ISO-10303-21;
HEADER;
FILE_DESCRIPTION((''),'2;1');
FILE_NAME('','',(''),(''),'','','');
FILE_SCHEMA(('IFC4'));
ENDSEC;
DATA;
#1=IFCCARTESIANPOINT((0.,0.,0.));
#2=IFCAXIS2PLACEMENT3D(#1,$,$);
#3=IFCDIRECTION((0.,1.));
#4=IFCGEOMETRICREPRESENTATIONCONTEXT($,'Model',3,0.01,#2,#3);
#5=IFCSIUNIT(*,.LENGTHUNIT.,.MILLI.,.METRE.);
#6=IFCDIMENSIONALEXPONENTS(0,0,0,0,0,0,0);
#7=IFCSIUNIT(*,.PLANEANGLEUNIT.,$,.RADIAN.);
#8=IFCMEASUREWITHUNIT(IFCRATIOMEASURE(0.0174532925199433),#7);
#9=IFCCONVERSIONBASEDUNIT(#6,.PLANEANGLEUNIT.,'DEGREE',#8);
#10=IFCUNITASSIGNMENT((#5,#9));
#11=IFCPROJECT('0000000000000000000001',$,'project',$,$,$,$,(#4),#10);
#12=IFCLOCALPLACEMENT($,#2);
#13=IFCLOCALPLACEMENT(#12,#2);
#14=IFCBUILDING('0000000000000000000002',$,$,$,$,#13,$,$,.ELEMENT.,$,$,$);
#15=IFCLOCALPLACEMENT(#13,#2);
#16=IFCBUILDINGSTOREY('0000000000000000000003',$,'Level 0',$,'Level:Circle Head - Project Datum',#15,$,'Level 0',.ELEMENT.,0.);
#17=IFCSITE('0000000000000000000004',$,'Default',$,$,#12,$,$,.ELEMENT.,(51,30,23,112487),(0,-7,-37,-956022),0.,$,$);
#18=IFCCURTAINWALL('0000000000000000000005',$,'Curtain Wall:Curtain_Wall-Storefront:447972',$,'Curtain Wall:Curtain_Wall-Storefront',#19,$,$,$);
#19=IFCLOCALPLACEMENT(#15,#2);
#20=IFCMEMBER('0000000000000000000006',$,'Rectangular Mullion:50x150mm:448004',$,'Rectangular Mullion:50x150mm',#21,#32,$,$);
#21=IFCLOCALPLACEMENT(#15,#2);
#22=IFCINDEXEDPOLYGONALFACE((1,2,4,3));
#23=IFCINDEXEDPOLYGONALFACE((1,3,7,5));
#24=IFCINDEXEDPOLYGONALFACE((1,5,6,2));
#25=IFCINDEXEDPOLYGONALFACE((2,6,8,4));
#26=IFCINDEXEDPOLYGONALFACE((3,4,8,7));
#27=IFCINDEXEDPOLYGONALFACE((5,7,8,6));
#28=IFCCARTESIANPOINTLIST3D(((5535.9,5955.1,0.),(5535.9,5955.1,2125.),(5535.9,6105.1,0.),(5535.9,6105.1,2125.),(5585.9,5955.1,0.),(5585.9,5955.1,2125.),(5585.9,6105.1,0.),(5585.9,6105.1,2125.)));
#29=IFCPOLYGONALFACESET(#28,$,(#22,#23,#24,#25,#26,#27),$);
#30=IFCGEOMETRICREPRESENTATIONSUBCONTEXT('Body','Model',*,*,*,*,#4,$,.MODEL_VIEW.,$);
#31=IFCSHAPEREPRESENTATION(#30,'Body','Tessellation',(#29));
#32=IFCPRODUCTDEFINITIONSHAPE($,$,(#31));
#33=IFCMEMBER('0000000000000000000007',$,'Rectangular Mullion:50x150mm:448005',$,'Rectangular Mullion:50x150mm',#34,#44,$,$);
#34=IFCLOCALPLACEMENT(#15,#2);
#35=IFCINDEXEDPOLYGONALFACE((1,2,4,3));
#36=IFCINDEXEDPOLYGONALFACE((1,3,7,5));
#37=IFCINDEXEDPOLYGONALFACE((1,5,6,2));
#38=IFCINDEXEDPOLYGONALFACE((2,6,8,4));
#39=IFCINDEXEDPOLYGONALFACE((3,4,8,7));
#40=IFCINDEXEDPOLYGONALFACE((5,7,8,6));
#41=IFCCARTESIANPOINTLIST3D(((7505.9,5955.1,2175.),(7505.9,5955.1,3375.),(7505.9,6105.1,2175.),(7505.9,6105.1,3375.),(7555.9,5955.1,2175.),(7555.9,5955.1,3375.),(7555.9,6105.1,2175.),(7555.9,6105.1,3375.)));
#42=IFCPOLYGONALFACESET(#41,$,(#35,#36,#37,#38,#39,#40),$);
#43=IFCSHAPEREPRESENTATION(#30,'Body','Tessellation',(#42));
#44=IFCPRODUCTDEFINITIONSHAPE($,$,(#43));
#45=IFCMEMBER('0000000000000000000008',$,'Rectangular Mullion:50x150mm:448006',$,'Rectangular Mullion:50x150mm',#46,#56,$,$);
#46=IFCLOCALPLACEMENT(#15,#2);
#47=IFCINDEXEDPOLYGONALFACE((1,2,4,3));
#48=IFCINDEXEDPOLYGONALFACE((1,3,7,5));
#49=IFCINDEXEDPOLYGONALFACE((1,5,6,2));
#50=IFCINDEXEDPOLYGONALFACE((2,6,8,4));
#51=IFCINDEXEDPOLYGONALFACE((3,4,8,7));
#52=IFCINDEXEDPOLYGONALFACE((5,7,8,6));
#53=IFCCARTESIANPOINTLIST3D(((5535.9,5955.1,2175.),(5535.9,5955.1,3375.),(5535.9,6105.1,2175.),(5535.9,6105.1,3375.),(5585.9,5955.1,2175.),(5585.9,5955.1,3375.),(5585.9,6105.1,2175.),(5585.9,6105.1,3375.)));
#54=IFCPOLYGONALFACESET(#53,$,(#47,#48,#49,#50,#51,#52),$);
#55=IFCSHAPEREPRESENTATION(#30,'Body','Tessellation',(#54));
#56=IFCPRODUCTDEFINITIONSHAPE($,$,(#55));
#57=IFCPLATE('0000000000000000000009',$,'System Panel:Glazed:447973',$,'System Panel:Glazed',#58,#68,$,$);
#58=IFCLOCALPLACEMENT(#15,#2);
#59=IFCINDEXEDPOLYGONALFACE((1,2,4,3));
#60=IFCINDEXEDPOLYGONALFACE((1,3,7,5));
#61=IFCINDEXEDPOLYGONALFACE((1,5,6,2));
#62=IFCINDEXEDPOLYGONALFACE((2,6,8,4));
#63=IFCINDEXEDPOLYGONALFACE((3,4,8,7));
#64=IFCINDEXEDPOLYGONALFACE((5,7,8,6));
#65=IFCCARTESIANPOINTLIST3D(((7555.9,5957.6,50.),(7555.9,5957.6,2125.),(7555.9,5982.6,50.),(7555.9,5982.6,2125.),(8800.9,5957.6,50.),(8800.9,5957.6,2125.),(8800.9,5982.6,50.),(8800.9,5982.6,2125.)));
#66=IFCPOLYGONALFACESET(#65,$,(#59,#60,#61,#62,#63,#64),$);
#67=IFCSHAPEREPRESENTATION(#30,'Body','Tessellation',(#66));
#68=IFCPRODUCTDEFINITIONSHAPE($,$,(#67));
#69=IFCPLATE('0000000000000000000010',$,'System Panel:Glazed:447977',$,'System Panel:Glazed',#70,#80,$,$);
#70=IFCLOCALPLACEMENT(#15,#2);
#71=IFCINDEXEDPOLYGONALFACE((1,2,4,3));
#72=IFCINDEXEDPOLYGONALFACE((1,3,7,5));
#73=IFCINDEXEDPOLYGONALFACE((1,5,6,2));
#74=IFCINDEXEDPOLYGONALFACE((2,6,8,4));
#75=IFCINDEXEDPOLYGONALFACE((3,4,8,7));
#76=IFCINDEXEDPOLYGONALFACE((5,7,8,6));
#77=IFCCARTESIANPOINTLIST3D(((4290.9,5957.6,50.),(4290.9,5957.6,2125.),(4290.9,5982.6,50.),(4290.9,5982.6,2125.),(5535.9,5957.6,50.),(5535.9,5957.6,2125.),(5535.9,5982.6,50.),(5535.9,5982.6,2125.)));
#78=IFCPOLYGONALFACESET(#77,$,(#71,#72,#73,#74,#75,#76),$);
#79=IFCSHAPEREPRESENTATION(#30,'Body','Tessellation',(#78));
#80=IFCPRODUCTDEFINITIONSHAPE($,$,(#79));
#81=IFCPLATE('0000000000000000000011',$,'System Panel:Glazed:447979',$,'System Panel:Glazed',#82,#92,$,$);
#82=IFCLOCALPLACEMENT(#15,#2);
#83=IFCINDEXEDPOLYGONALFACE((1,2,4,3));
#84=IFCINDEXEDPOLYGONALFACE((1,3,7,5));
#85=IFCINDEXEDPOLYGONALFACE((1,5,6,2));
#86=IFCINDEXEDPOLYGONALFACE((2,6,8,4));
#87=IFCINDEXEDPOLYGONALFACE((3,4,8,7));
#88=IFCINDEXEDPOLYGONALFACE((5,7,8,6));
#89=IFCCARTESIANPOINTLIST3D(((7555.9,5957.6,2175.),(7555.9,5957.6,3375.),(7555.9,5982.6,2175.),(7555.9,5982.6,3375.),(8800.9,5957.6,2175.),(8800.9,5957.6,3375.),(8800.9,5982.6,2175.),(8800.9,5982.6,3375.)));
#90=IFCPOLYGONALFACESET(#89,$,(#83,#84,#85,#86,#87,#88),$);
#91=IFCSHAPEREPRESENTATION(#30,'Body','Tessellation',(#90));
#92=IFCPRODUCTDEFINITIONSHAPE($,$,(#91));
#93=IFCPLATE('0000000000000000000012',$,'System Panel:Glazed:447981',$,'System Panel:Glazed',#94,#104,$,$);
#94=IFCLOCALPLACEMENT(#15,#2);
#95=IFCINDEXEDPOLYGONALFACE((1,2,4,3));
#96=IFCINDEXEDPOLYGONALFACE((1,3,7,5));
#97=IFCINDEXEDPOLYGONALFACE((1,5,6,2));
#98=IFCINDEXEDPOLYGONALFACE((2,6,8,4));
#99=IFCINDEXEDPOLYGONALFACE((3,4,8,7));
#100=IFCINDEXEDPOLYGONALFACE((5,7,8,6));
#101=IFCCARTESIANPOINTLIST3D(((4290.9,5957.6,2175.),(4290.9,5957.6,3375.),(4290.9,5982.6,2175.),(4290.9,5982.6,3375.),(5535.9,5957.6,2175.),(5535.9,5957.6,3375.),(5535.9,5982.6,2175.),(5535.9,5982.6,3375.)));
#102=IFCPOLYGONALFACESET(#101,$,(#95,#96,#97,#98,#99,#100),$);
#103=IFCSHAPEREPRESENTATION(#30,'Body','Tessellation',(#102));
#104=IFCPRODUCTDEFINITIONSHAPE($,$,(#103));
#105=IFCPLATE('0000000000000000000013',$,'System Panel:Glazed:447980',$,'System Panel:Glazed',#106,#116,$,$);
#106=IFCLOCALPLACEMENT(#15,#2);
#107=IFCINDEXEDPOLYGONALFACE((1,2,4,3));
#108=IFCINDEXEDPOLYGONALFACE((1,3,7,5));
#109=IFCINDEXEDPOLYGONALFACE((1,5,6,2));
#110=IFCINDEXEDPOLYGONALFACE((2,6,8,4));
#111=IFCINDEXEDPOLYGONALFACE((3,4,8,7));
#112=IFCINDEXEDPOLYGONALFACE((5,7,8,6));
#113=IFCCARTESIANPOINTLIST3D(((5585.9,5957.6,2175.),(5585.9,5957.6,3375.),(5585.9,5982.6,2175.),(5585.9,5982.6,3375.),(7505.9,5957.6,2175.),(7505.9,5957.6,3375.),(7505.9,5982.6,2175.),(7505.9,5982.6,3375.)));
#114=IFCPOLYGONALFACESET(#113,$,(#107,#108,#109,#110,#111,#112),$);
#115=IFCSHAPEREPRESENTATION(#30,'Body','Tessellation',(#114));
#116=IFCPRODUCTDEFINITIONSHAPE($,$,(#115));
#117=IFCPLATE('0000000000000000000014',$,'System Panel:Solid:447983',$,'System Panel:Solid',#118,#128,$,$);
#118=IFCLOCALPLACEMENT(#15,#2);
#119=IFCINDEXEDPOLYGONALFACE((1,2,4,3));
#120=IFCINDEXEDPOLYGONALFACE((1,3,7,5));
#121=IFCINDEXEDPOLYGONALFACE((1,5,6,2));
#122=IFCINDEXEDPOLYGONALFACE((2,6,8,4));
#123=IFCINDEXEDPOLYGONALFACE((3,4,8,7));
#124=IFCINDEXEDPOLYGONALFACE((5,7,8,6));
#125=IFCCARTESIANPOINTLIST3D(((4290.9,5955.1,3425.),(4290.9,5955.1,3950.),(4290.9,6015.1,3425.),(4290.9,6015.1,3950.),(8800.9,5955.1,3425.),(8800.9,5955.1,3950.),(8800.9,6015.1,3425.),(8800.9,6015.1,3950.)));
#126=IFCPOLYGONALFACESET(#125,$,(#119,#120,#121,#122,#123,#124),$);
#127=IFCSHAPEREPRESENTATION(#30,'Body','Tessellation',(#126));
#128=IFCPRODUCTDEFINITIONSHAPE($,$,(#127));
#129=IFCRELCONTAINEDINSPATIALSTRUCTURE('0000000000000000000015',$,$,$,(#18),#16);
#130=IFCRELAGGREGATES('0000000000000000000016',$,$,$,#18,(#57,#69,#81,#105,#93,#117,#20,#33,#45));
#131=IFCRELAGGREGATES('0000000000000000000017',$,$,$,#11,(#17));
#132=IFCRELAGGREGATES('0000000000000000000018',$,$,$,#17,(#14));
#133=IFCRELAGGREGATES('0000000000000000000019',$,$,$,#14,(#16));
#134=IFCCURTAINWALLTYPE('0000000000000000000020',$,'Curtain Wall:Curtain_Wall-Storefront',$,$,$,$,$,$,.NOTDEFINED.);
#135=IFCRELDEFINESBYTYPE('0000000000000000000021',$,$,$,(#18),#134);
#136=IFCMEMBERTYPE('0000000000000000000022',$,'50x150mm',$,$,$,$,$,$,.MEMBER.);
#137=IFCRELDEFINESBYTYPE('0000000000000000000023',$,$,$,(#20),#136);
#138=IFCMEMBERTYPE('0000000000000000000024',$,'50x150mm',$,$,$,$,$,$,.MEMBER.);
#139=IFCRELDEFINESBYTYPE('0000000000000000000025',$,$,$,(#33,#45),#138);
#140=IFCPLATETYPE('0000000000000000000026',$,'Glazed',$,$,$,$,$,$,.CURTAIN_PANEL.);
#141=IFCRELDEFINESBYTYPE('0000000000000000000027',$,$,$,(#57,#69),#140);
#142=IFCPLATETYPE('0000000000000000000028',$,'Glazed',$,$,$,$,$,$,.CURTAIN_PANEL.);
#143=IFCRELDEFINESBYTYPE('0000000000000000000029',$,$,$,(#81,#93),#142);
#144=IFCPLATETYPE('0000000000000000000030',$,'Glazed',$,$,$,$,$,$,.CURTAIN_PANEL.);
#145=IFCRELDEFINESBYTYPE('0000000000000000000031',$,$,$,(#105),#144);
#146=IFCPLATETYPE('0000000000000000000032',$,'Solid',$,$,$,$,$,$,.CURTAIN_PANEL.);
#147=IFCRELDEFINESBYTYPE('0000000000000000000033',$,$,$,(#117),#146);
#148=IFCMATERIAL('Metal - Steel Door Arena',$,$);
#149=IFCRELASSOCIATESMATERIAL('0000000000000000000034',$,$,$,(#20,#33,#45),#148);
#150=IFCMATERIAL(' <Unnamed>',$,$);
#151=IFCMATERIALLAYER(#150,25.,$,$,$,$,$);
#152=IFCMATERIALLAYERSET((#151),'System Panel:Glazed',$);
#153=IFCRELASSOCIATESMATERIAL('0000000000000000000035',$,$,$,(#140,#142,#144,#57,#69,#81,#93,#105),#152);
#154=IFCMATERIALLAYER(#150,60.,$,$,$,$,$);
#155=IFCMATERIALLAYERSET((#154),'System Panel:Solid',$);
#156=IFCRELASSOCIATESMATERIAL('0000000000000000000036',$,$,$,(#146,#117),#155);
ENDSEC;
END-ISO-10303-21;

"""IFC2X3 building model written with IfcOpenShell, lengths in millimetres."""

from ifc_helpers import new_model, entity, si_unit, converted_unit, direction, frame, frame_2d, origin, origin_2d_with_axis, place, context, subcontext, project, spatial, rectangle, extrude, source, transform, mapped, material, layer, layer_set, layer_usage, type_object, type_shapes, element, aggregate, save


model = new_model("IFC2X3")

# Units and contexts
model_context = context("Model", 3, precision=0.01, world=origin(), true_north=direction((0.0, 1.0)))
body_context = subcontext(model_context, "Body", "Model", "MODEL_VIEW")
ifc_project = project(units=[si_unit("LENGTHUNIT", "METRE", prefix="MILLI"), converted_unit("PLANEANGLEUNIT", "DEGREE", entity("IfcRatioMeasure", 0.0174532925199433), si_unit("PLANEANGLEUNIT", "RADIAN"), dimensions=[0, 0, 0, 0, 0, 0, 0])], contexts=[model_context])

# Site, building, storey
site_placement = place(None, origin())
site = spatial("IfcSite", under=ifc_project, at=site_placement, Name="Default", CompositionType="ELEMENT", RefLatitude=(51, 30, 23, 112487), RefLongitude=(0, -7, -37, -956022), RefElevation=0.0)
building_placement = place(site_placement, origin())
building = spatial("IfcBuilding", under=site, at=building_placement, CompositionType="ELEMENT")
storey_placement = place(building_placement, origin())
storey = spatial("IfcBuildingStorey", under=building, at=storey_placement, Name="Level 0", ObjectType="Level:Circle Head - Project Datum", LongName="Level 0", CompositionType="ELEMENT", Elevation=0.0)

# Curtain wall, members, plates
curtain_wall_type = type_object("IfcCurtainWallType", Name="Curtain Wall:Curtain_Wall-Storefront", PredefinedType="NOTDEFINED")
curtain_wall_placement = place(storey_placement, origin())
curtain_wall = element("IfcCurtainWall", 1, at=curtain_wall_placement, inside=storey, type_object=curtain_wall_type, Name="Curtain Wall:Curtain_Wall-Storefront:447972", ObjectType="Curtain Wall:Curtain_Wall-Storefront")
ifc_material_1 = material(Name="Metal - Steel Door Arena")
member_type_1 = type_object("IfcMemberType", Name="50x150mm", PredefinedType="MEMBER")
shared_shape_1 = source(origin(), body_context, "Body", "SweptSolid", [
    extrude(rectangle(XDim=150.0, YDim=50.0, at=origin_2d_with_axis()), frame((0.0, 0.0, -2125.0), z_axis=(0.0, 0.0, 1.0), x_axis=(0.0, -1.0, 0.0)), (0.0, 0.0, 1.0), 2125.0),
])
type_shapes(member_type_1, [shared_shape_1])
member_1_placement = place(storey_placement, frame((5560.9, 6030.1, 0.0), z_axis=(0.0, 0.0, -1.0), x_axis=(-1.0, 0.0, 0.0)))
member_1 = element("IfcMember", 2, at=member_1_placement, type_object=member_type_1, material=ifc_material_1, Name="Rectangular Mullion:50x150mm:448004", ObjectType="Rectangular Mullion:50x150mm", context=body_context, shape_type="MappedRepresentation", body=[
    mapped(shared_shape_1, transform((0.0, 0.0, 0.0), scale=1.0)),
])
member_type_2 = type_object("IfcMemberType", Name="50x150mm", PredefinedType="MEMBER")
shared_shape_2 = source(origin(), body_context, "Body", "SweptSolid", [
    extrude(rectangle(XDim=150.0, YDim=50.0, at=origin_2d_with_axis()), frame((0.0, 0.0, -1200.0), z_axis=(0.0, 0.0, 1.0), x_axis=(0.0, -1.0, 0.0)), (0.0, 0.0, 1.0), 1200.0),
])
type_shapes(member_type_2, [shared_shape_2])
member_2_placement = place(storey_placement, frame((7530.9, 6030.1, 2175.0), z_axis=(0.0, 0.0, -1.0), x_axis=(-1.0, 0.0, 0.0)))
member_2 = element("IfcMember", 3, at=member_2_placement, type_object=member_type_2, material=ifc_material_1, Name="Rectangular Mullion:50x150mm:448005", ObjectType="Rectangular Mullion:50x150mm", context=body_context, shape_type="MappedRepresentation", body=[
    mapped(shared_shape_2, transform((0.0, 0.0, 0.0), scale=1.0)),
])
member_3_placement = place(storey_placement, frame((5560.9, 6030.1, 2175.0), z_axis=(0.0, 0.0, -1.0), x_axis=(-1.0, 0.0, 0.0)))
member_3 = element("IfcMember", 4, at=member_3_placement, type_object=member_type_2, material=ifc_material_1, Name="Rectangular Mullion:50x150mm:448006", ObjectType="Rectangular Mullion:50x150mm", context=body_context, shape_type="MappedRepresentation", body=[
    mapped(shared_shape_2, transform((0.0, 0.0, 0.0), scale=1.0)),
])
ifc_material_2 = material(Name=" <Unnamed>")
ifc_layer_1 = layer(ifc_material_2, 25.0)
ifc_layer_set_1 = layer_set([ifc_layer_1], Name="System Panel:Glazed")
ifc_layer_usage_1 = layer_usage(ifc_layer_set_1, "AXIS3", "POSITIVE", 0.2)
plate_type_1 = type_object("IfcPlateType", Name="Glazed", PredefinedType="CURTAIN_PANEL", material=ifc_layer_set_1)
shared_shape_3 = source(origin(), body_context, "Body", "SweptSolid", [
    extrude(rectangle(XDim=25.0, YDim=1245.0, at=origin_2d_with_axis()), frame((0.0, 60.0, 0.0), z_axis=(0.0, 0.0, 1.0), x_axis=(0.0, 1.0, 0.0)), (0.0, 0.0, 1.0), 2075.0),
])
type_shapes(plate_type_1, [shared_shape_3])
plate_1_placement = place(curtain_wall_placement, frame((8178.4, 6030.1, 50.0), z_axis=(0.0, 0.0, 1.0), x_axis=(-1.0, 0.0, 0.0)))
plate_1 = element("IfcPlate", 5, at=plate_1_placement, type_object=plate_type_1, material=ifc_layer_usage_1, Name="System Panel:Glazed:447973", ObjectType="System Panel:Glazed", context=body_context, shape_type="MappedRepresentation", body=[
    mapped(shared_shape_3, transform((0.0, 0.0, 0.0), scale=1.0)),
])
ifc_layer_usage_2 = layer_usage(ifc_layer_set_1, "AXIS3", "POSITIVE", 0.2)
plate_2_placement = place(curtain_wall_placement, frame((4913.4, 6030.1, 50.0), z_axis=(0.0, 0.0, 1.0), x_axis=(-1.0, 0.0, 0.0)))
plate_2 = element("IfcPlate", 6, at=plate_2_placement, type_object=plate_type_1, material=ifc_layer_usage_2, Name="System Panel:Glazed:447977", ObjectType="System Panel:Glazed", context=body_context, shape_type="MappedRepresentation", body=[
    mapped(shared_shape_3, transform((0.0, 0.0, 0.0), scale=1.0)),
])
ifc_layer_usage_3 = layer_usage(ifc_layer_set_1, "AXIS3", "POSITIVE", 0.2)
plate_type_2 = type_object("IfcPlateType", Name="Glazed", PredefinedType="CURTAIN_PANEL", material=ifc_layer_set_1)
shared_shape_4 = source(origin(), body_context, "Body", "SweptSolid", [
    extrude(rectangle(XDim=25.0, YDim=1245.0, at=origin_2d_with_axis()), frame((0.0, 60.0, 0.0), z_axis=(0.0, 0.0, 1.0), x_axis=(0.0, 1.0, 0.0)), (0.0, 0.0, 1.0), 1200.0),
])
type_shapes(plate_type_2, [shared_shape_4])
plate_3_placement = place(curtain_wall_placement, frame((8178.4, 6030.1, 2175.0), z_axis=(0.0, 0.0, 1.0), x_axis=(-1.0, 0.0, 0.0)))
plate_3 = element("IfcPlate", 7, at=plate_3_placement, type_object=plate_type_2, material=ifc_layer_usage_3, Name="System Panel:Glazed:447979", ObjectType="System Panel:Glazed", context=body_context, shape_type="MappedRepresentation", body=[
    mapped(shared_shape_4, transform((0.0, 0.0, 0.0), scale=1.0)),
])
ifc_layer_usage_4 = layer_usage(ifc_layer_set_1, "AXIS3", "POSITIVE", 0.2)
plate_4_placement = place(curtain_wall_placement, frame((4913.4, 6030.1, 2175.0), z_axis=(0.0, 0.0, 1.0), x_axis=(-1.0, 0.0, 0.0)))
plate_4 = element("IfcPlate", 8, at=plate_4_placement, type_object=plate_type_2, material=ifc_layer_usage_4, Name="System Panel:Glazed:447981", ObjectType="System Panel:Glazed", context=body_context, shape_type="MappedRepresentation", body=[
    mapped(shared_shape_4, transform((0.0, 0.0, 0.0), scale=1.0)),
])
ifc_layer_usage_5 = layer_usage(ifc_layer_set_1, "AXIS3", "POSITIVE", 0.2)
plate_type_3 = type_object("IfcPlateType", Name="Glazed", PredefinedType="CURTAIN_PANEL", material=ifc_layer_set_1)
shared_shape_5 = source(origin(), body_context, "Body", "SweptSolid", [
    extrude(rectangle(XDim=25.0, YDim=1920.0, at=origin_2d_with_axis()), frame((0.0, 60.0, 0.0), z_axis=(0.0, 0.0, 1.0), x_axis=(0.0, 1.0, 0.0)), (0.0, 0.0, 1.0), 1200.0),
])
type_shapes(plate_type_3, [shared_shape_5])
plate_5_placement = place(curtain_wall_placement, frame((6545.9, 6030.1, 2175.0), z_axis=(0.0, 0.0, 1.0), x_axis=(-1.0, 0.0, 0.0)))
plate_5 = element("IfcPlate", 9, at=plate_5_placement, type_object=plate_type_3, material=ifc_layer_usage_5, Name="System Panel:Glazed:447980", ObjectType="System Panel:Glazed", context=body_context, shape_type="MappedRepresentation", body=[
    mapped(shared_shape_5, transform((0.0, 0.0, 0.0), scale=1.0)),
])
ifc_layer_2 = layer(ifc_material_2, 60.0)
ifc_layer_set_2 = layer_set([ifc_layer_2], Name="System Panel:Solid")
ifc_layer_usage_6 = layer_usage(ifc_layer_set_2, "AXIS3", "POSITIVE", 0.1)
plate_type_4 = type_object("IfcPlateType", Name="Solid", PredefinedType="CURTAIN_PANEL", material=ifc_layer_set_2)
shared_shape_6 = source(origin(), body_context, "Body", "SweptSolid", [
    extrude(rectangle(XDim=525.0, YDim=4510.0, at=frame_2d((0.0, 0.0), x_axis=(1.0, 0.0))), frame((0.0, 15.0, 262.5), z_axis=(0.0, 1.0, 0.0), x_axis=(0.0, 0.0, 1.0)), (0.0, 0.0, 1.0), 60.0),
])
type_shapes(plate_type_4, [shared_shape_6])
plate_6_placement = place(curtain_wall_placement, frame((6545.9, 6030.1, 3425.0), z_axis=(0.0, 0.0, 1.0), x_axis=(-1.0, 0.0, 0.0)))
plate_6 = element("IfcPlate", 10, at=plate_6_placement, type_object=plate_type_4, material=ifc_layer_usage_6, Name="System Panel:Solid:447983", ObjectType="System Panel:Solid", context=body_context, shape_type="MappedRepresentation", body=[
    mapped(shared_shape_6, transform((0.0, 0.0, 0.0), scale=1.0)),
])
aggregate(curtain_wall, [plate_1, plate_2, plate_3, plate_5, plate_4, plate_6, member_1, member_2, member_3])

save(model, "model.ifc")
